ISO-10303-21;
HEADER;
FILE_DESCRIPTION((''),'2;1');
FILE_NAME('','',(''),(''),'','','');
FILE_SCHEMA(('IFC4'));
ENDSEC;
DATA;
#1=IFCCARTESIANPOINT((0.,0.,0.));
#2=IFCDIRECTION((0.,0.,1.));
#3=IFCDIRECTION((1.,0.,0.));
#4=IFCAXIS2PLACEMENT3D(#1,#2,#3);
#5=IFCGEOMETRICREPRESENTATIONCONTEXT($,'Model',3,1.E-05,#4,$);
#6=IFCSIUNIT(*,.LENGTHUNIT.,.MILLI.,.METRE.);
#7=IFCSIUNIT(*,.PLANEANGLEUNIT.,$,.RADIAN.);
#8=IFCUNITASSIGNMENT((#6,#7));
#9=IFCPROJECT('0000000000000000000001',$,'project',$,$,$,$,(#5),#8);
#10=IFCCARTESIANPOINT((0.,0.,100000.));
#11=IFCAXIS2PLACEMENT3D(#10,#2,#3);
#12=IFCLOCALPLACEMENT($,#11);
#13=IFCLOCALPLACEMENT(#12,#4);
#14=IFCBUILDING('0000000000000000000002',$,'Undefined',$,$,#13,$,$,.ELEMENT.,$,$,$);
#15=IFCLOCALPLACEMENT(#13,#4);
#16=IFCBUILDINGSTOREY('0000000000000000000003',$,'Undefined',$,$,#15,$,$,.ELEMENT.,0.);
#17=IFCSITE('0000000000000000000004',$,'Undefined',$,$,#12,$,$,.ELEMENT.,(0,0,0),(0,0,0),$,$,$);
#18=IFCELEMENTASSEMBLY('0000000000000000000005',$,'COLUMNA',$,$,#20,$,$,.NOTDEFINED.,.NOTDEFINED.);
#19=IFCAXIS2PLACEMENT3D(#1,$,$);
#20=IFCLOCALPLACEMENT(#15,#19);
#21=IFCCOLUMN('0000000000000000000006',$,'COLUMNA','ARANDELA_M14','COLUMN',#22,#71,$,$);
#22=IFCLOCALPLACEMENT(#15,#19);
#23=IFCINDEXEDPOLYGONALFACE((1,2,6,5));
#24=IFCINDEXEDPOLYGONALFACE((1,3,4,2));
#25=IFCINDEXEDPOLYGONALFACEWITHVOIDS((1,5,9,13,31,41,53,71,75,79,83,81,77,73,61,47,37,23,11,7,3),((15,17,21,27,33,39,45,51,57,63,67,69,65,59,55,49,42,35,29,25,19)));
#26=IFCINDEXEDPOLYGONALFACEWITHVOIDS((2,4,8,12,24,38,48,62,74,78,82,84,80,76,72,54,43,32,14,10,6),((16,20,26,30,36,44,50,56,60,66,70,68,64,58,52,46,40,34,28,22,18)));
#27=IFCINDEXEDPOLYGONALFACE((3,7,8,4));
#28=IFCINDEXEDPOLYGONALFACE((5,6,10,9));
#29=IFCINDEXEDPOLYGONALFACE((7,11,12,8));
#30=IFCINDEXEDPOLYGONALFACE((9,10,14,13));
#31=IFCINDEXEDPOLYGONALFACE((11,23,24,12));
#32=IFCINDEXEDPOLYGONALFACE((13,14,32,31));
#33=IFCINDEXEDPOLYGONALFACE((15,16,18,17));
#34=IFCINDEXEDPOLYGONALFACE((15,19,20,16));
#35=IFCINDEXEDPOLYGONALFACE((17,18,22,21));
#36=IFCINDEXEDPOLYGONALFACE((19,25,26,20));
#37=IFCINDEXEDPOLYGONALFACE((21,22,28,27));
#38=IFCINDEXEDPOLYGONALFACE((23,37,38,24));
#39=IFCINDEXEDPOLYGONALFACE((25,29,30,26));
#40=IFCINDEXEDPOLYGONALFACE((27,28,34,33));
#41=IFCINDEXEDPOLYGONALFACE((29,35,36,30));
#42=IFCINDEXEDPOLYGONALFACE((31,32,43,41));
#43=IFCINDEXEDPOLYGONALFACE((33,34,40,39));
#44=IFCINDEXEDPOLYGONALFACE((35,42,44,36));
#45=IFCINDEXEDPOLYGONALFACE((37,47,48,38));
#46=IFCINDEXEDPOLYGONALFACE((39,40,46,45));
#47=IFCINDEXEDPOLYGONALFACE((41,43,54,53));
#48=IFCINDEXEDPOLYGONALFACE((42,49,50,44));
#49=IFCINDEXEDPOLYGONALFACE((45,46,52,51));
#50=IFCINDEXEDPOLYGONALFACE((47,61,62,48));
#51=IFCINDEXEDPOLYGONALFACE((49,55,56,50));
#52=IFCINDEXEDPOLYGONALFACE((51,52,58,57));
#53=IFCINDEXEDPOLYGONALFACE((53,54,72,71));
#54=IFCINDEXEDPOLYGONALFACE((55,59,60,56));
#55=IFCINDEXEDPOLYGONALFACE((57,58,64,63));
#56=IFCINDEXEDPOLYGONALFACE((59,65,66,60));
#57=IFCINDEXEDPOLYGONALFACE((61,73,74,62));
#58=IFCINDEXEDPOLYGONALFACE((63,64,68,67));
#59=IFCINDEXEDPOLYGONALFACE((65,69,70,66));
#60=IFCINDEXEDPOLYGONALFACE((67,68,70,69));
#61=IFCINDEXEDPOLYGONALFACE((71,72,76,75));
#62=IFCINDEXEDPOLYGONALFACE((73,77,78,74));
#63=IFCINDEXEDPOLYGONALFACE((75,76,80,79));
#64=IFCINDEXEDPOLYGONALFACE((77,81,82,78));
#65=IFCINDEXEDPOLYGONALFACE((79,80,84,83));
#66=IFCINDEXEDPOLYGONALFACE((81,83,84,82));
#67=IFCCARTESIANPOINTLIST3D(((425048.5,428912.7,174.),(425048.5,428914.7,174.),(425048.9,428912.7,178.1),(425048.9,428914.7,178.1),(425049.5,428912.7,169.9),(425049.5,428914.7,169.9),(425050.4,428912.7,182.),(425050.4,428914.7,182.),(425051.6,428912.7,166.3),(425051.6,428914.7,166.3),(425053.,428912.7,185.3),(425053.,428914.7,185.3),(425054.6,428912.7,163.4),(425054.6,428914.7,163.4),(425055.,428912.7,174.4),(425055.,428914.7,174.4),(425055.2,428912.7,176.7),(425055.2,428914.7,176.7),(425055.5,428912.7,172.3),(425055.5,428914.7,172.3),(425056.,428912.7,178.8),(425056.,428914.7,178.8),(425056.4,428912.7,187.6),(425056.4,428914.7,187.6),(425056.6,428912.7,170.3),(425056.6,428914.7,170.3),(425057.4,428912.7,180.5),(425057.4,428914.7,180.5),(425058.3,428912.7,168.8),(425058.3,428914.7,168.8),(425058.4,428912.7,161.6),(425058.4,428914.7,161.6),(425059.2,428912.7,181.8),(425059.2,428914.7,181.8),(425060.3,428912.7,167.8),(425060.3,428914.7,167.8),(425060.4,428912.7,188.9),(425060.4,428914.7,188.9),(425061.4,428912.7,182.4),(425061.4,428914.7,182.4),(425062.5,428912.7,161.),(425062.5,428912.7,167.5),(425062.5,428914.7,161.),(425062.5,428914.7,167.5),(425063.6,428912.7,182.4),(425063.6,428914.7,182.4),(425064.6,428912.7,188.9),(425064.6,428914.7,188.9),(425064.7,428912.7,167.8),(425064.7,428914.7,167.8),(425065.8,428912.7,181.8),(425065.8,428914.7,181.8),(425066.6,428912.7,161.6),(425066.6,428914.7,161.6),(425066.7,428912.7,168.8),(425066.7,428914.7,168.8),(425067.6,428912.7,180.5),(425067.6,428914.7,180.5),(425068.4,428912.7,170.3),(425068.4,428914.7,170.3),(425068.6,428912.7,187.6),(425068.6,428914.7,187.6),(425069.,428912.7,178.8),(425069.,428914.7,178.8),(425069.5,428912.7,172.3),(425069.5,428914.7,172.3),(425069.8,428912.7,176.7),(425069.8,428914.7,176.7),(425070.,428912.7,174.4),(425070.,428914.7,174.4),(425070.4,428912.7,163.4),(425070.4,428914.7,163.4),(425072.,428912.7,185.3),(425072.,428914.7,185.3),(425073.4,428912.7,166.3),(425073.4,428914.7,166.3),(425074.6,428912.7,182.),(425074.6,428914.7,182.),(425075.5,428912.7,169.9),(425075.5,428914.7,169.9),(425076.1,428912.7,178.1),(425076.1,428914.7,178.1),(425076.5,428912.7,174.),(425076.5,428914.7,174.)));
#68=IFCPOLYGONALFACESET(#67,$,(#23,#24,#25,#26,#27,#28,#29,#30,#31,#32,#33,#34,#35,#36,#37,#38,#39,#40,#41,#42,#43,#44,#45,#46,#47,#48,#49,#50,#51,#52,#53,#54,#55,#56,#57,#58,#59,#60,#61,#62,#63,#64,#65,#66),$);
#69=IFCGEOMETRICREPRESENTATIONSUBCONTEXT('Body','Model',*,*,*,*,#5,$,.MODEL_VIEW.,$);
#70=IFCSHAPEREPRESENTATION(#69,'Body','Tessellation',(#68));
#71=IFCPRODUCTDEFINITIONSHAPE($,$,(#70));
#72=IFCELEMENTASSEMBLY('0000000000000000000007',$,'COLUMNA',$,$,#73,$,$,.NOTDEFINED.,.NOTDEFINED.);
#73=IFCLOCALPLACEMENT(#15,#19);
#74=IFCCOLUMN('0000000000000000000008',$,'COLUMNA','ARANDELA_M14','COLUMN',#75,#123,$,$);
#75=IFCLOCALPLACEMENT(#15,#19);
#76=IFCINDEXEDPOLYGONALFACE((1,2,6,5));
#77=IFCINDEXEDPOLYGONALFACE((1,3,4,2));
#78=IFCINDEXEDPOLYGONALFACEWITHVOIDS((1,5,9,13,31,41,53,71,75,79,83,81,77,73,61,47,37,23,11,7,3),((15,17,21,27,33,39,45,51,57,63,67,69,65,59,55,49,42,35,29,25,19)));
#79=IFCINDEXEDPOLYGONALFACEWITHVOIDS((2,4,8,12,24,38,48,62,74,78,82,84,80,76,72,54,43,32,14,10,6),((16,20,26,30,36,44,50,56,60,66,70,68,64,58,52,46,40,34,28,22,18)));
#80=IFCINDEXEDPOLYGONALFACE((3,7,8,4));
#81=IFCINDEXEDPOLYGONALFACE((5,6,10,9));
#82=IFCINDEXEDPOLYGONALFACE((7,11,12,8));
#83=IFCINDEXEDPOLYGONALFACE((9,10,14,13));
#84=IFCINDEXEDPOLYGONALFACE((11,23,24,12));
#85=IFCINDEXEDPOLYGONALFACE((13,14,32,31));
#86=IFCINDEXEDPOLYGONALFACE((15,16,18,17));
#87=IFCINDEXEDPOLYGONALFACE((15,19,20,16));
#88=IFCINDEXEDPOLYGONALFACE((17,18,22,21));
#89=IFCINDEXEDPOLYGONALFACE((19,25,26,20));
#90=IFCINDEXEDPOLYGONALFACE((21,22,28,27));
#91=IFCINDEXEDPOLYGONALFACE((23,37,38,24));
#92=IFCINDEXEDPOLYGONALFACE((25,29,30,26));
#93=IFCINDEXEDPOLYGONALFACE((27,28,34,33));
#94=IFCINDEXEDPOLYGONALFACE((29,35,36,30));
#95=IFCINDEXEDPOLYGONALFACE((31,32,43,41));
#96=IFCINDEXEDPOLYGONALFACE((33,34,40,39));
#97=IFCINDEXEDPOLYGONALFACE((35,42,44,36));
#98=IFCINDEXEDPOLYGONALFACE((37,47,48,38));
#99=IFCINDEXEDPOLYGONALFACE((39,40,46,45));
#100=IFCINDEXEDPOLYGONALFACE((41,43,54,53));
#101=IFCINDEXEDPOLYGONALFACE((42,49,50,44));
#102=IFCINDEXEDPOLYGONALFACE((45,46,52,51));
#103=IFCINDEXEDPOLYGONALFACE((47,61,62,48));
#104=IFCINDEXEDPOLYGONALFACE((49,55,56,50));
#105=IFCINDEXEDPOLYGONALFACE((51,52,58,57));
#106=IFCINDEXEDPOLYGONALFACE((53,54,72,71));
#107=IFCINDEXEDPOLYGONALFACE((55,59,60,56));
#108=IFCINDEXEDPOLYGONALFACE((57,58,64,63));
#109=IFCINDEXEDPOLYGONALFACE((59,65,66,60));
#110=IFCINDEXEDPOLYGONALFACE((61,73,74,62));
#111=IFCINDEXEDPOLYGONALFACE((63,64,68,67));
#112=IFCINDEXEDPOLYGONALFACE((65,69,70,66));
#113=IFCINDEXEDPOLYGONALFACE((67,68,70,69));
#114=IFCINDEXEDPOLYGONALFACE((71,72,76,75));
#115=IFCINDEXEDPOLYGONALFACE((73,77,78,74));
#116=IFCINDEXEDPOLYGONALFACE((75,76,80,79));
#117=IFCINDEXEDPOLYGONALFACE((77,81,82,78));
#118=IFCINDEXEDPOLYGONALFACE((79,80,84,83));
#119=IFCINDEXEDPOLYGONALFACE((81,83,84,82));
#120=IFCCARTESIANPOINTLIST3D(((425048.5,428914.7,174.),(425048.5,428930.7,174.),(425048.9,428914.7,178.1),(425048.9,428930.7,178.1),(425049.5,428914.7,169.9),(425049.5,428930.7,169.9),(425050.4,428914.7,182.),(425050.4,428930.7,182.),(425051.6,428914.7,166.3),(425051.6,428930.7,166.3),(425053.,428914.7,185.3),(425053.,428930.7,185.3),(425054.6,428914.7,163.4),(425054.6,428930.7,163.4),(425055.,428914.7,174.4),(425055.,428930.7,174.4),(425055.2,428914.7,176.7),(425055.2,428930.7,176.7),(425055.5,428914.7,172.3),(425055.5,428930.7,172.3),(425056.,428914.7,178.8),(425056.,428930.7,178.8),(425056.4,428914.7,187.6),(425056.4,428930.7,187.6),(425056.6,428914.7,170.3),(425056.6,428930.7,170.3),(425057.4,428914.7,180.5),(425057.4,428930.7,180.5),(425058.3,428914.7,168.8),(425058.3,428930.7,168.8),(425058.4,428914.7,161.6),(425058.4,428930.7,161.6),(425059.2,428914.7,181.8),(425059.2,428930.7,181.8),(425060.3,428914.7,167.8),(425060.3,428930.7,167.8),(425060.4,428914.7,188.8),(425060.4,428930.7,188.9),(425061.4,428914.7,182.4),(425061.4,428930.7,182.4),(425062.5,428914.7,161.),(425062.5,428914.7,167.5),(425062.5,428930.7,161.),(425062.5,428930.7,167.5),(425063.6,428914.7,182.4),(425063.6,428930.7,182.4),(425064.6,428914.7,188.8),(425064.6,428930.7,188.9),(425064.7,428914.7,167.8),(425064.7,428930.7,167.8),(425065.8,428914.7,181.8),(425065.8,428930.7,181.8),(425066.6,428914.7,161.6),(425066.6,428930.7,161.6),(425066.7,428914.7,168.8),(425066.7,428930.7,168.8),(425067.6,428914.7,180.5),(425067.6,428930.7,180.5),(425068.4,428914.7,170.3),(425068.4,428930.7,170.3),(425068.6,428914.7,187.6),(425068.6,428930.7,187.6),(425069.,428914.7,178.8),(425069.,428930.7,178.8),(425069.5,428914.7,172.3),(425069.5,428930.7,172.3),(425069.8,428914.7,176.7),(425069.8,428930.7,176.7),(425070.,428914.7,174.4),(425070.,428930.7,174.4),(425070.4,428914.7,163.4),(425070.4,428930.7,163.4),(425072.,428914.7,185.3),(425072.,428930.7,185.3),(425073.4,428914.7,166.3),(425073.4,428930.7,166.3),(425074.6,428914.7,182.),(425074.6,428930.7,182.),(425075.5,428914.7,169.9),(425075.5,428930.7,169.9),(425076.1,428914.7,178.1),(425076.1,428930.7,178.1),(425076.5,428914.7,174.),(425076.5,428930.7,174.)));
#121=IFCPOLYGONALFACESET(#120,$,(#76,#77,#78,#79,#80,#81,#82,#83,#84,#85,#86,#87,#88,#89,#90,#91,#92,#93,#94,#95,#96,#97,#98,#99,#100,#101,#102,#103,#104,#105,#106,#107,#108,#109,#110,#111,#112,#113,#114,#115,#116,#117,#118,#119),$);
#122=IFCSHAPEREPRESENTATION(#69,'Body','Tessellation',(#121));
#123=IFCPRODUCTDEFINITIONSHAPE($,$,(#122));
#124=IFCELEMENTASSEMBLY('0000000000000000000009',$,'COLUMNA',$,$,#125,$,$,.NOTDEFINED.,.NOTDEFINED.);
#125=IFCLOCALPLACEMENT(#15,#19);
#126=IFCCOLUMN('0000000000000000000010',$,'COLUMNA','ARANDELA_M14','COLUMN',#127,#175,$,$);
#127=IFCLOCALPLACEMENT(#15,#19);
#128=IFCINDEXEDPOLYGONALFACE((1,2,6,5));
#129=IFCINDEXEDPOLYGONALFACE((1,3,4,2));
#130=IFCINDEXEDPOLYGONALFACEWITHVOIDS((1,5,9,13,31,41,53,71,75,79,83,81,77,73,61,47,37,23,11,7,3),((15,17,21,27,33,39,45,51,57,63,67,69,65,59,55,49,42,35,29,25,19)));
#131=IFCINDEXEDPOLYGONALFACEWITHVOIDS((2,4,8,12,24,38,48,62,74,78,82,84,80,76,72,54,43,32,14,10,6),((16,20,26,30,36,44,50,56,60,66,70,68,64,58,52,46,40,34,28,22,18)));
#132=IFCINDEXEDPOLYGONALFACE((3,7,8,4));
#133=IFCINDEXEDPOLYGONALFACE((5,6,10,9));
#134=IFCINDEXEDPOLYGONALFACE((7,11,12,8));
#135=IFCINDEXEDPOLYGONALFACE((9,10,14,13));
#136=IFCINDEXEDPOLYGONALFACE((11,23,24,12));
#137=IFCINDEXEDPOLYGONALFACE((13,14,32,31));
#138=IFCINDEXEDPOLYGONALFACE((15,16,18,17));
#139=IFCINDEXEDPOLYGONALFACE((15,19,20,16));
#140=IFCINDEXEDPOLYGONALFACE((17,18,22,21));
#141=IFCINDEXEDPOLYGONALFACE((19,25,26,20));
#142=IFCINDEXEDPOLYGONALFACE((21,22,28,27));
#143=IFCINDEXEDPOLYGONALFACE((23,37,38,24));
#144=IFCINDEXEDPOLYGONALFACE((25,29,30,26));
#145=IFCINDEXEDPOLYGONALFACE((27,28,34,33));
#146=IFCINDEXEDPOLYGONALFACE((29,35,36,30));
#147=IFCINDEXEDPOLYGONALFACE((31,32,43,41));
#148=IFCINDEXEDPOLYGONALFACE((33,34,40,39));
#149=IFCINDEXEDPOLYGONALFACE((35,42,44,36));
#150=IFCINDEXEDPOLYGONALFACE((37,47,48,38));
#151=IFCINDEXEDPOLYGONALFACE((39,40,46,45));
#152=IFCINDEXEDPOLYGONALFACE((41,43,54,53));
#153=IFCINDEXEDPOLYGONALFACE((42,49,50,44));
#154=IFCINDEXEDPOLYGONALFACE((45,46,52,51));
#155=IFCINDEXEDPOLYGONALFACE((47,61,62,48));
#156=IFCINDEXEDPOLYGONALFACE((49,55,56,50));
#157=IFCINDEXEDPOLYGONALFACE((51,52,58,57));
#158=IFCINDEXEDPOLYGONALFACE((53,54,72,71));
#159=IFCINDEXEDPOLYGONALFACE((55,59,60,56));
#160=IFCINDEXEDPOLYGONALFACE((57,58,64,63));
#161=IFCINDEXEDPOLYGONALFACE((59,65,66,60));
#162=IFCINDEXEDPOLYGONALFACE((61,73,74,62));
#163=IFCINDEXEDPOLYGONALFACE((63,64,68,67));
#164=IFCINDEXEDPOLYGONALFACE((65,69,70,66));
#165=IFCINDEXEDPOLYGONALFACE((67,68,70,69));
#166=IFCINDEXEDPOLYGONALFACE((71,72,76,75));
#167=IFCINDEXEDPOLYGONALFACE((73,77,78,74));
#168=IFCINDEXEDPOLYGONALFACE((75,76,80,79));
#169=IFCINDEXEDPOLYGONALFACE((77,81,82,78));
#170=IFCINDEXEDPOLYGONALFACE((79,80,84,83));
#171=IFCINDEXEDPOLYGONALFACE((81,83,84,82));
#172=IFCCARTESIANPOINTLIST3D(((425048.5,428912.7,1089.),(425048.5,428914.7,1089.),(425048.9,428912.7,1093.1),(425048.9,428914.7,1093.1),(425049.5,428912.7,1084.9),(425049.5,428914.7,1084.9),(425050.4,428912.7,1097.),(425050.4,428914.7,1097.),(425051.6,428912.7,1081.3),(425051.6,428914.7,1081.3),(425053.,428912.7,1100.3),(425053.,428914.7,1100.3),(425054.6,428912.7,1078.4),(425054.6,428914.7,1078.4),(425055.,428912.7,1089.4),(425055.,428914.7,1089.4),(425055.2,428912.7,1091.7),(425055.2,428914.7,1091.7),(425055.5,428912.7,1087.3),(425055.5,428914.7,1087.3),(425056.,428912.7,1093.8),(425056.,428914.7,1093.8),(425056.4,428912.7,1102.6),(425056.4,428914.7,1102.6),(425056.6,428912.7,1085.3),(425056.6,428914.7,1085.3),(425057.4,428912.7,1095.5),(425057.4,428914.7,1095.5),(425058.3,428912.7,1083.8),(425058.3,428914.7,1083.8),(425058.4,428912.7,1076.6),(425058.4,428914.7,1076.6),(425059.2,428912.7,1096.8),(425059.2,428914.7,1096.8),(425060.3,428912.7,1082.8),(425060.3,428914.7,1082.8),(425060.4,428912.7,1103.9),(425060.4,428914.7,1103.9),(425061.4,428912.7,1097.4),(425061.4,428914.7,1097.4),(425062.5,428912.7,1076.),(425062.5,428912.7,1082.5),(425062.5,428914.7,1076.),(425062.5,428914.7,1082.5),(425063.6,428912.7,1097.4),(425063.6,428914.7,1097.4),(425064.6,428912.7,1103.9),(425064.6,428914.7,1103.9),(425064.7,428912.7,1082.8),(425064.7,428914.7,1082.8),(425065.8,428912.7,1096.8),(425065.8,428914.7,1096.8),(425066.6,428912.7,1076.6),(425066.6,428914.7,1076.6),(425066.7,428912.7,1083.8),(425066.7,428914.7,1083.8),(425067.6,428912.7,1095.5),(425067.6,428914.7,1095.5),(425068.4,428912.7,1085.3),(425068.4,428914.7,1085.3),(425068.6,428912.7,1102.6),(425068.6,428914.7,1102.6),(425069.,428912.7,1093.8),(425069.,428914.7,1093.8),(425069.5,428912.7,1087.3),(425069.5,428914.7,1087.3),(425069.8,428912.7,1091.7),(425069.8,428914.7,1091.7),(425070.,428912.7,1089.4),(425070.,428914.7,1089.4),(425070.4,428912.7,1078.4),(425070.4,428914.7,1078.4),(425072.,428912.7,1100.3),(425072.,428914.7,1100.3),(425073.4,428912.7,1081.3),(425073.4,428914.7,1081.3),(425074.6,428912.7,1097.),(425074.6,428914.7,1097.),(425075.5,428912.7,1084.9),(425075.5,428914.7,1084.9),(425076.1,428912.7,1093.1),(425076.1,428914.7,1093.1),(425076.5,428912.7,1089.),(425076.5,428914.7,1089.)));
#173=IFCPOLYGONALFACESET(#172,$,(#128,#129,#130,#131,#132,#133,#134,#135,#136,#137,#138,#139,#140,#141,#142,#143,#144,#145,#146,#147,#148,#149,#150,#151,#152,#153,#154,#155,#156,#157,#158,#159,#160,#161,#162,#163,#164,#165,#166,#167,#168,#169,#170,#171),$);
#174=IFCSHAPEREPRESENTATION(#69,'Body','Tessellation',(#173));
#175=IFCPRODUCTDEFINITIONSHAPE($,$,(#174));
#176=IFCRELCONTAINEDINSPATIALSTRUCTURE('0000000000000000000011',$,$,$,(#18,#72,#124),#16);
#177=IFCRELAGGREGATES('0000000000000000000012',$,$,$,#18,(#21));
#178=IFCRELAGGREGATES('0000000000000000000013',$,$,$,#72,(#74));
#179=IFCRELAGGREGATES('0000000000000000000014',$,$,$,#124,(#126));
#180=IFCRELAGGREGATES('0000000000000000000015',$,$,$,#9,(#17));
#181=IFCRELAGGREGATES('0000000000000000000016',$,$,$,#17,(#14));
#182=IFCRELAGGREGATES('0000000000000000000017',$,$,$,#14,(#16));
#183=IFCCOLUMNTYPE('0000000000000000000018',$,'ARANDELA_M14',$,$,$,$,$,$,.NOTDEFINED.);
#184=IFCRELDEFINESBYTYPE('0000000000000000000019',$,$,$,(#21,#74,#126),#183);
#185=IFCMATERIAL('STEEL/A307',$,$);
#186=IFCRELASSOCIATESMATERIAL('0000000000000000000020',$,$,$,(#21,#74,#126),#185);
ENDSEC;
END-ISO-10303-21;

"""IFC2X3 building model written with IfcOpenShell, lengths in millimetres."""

from ifc_helpers import new_model, si_unit, frame, origin_with_axes, origin_2d_with_axis, place, context, subcontext, project, spatial, hollow_circle, extrude, material, type_object, element, aggregate, save


model = new_model("IFC2X3")

# Units and contexts
model_context = context("Model", 3, precision=1e-05, world=origin_with_axes())
body_context = subcontext(model_context, "Body", "Model", "MODEL_VIEW")
ifc_project = project(units=[si_unit("LENGTHUNIT", "METRE", prefix="MILLI"), si_unit("PLANEANGLEUNIT", "RADIAN")], contexts=[model_context])

# Site, building, storey
site_placement = place(None, frame((0.0, 0.0, 100000.0), z_axis=(0.0, 0.0, 1.0), x_axis=(1.0, 0.0, 0.0)))
site = spatial("IfcSite", under=ifc_project, at=site_placement, Name="Undefined", CompositionType="ELEMENT", RefLatitude=(0, 0, 0), RefLongitude=(0, 0, 0))
building_placement = place(site_placement, origin_with_axes())
building = spatial("IfcBuilding", under=site, at=building_placement, Name="Undefined", CompositionType="ELEMENT")
storey_placement = place(building_placement, origin_with_axes())
storey = spatial("IfcBuildingStorey", under=building, at=storey_placement, Name="Undefined", CompositionType="ELEMENT", Elevation=0.0)

# Element assemblies, columns
ifc_material = material(Name="STEEL/A307")
column_type_1 = type_object("IfcColumnType", Name="ARANDELA_M14", PredefinedType="NOTDEFINED")
assembly_1_placement = place(storey_placement, origin_with_axes())
assembly_1 = element("IfcElementAssembly", 1, at=assembly_1_placement, inside=storey, Name="COLUMNA", AssemblyPlace="NOTDEFINED", PredefinedType="NOTDEFINED")
column_1_placement = place(assembly_1_placement, frame((425062.5, 428912.7, 175.0), z_axis=(0.0, 1.0, 0.000285), x_axis=(1.0, 0.0, 0.0)))
column_1 = element("IfcColumn", 2, at=column_1_placement, type_object=column_type_1, material=ifc_material, Name="COLUMNA", Description="ARANDELA_M14", ObjectType="COLUMN", context=body_context, shape_type="SweptSolid", body=[
    extrude(hollow_circle(Radius=14.0, WallThickness=6.5, at=origin_2d_with_axis()), frame((0.0, 0.0, 2.0), z_axis=(0.0, 0.0, -1.0), x_axis=(0.0, 1.0, 0.0)), (0.0, 0.0, 1.0), 2.0),
])
aggregate(assembly_1, [column_1])
assembly_2_placement = place(storey_placement, origin_with_axes())
assembly_2 = element("IfcElementAssembly", 3, at=assembly_2_placement, inside=storey, Name="COLUMNA", AssemblyPlace="NOTDEFINED", PredefinedType="NOTDEFINED")
column_2_placement = place(assembly_2_placement, frame((425062.5, 428914.7, 175.0), z_axis=(0.0, 1.0, 0.000285), x_axis=(1.0, 0.0, 0.0)))
column_2 = element("IfcColumn", 4, at=column_2_placement, type_object=column_type_1, material=ifc_material, Name="COLUMNA", Description="ARANDELA_M14", ObjectType="COLUMN", context=body_context, shape_type="SweptSolid", body=[
    extrude(hollow_circle(Radius=14.0, WallThickness=6.5, at=origin_2d_with_axis()), frame((0.0, 0.0, 16.0), z_axis=(0.0, 0.0, -1.0), x_axis=(0.0, 1.0, 0.0)), (0.0, 0.0, 1.0), 16.0),
])
aggregate(assembly_2, [column_2])
assembly_3_placement = place(storey_placement, origin_with_axes())
assembly_3 = element("IfcElementAssembly", 5, at=assembly_3_placement, inside=storey, Name="COLUMNA", AssemblyPlace="NOTDEFINED", PredefinedType="NOTDEFINED")
column_3_placement = place(assembly_3_placement, frame((425062.5, 428912.7, 1090.0), z_axis=(0.0, 1.0, 0.000285), x_axis=(1.0, 0.0, 0.0)))
column_3 = element("IfcColumn", 6, at=column_3_placement, type_object=column_type_1, material=ifc_material, Name="COLUMNA", Description="ARANDELA_M14", ObjectType="COLUMN", context=body_context, shape_type="SweptSolid", body=[
    extrude(hollow_circle(Radius=14.0, WallThickness=6.5, at=origin_2d_with_axis()), frame((0.0, 0.0, 2.0), z_axis=(0.0, 0.0, -1.0), x_axis=(0.0, 1.0, 0.0)), (0.0, 0.0, 1.0), 2.0),
])
aggregate(assembly_3, [column_3])

save(model, "model.ifc")
